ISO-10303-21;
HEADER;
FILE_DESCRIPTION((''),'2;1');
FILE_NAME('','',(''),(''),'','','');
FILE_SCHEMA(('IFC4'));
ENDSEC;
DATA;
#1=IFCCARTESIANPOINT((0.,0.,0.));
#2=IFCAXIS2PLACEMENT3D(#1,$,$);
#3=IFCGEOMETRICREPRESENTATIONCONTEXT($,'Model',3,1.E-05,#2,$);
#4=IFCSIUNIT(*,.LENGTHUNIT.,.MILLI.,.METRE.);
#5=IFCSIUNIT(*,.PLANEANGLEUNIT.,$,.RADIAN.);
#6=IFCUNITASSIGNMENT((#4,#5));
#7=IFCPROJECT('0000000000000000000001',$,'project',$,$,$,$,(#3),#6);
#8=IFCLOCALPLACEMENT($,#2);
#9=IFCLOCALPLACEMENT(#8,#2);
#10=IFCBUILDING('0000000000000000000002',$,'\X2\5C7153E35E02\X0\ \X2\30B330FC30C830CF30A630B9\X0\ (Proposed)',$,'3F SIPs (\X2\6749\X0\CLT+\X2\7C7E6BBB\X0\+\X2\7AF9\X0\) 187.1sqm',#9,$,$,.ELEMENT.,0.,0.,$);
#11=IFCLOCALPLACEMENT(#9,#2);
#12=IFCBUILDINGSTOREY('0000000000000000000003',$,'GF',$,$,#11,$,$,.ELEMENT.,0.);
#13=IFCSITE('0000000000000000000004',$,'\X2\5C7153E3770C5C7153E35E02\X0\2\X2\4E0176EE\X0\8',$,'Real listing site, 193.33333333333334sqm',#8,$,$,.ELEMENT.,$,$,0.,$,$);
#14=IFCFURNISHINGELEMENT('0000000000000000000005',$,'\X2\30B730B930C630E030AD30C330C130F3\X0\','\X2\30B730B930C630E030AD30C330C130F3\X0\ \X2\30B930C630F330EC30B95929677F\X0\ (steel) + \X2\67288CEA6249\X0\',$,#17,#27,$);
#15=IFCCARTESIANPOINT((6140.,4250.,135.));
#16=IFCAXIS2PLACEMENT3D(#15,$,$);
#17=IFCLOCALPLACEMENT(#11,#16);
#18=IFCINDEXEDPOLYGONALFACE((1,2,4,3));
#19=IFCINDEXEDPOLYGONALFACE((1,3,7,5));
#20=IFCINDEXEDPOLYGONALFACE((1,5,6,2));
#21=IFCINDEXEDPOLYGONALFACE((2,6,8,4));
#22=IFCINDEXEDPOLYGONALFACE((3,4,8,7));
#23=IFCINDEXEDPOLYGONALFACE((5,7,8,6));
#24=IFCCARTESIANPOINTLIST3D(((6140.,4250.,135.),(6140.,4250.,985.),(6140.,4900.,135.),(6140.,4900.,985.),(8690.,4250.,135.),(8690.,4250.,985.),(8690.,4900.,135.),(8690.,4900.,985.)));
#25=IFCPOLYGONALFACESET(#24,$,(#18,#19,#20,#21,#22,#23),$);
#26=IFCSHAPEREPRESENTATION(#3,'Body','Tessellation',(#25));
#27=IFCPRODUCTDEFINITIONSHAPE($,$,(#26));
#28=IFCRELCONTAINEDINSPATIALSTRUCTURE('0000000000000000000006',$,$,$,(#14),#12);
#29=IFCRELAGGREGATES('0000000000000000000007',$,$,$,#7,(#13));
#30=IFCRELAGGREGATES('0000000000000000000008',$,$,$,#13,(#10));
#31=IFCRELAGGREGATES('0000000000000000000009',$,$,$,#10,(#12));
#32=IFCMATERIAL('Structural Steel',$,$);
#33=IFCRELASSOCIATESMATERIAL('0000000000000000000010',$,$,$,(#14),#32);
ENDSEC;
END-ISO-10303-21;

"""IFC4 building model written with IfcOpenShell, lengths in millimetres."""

from ifc_helpers import new_model, si_unit, frame, frame_2d, origin, place, context, project, spatial, rectangle, extrude, material, element, save


model = new_model("IFC4")

# Units and contexts
model_context = context("Model", 3, precision=1e-05, world=origin())
ifc_project = project(units=[si_unit("LENGTHUNIT", "METRE", prefix="MILLI"), si_unit("PLANEANGLEUNIT", "RADIAN")], contexts=[model_context])

# Site, building, storey
site_placement = place(None, origin())
site = spatial("IfcSite", under=ifc_project, at=site_placement, Name="山口県山口市2丁目8", ObjectType="Real listing site, 193.33333333333334sqm", CompositionType="ELEMENT", RefElevation=0.0)
building_placement = place(site_placement, origin())
building = spatial("IfcBuilding", under=site, at=building_placement, Name="山口市 コートハウス (Proposed)", ObjectType="3F SIPs (杉CLT+籾殻+竹) 187.1sqm", CompositionType="ELEMENT", ElevationOfRefHeight=0.0, ElevationOfTerrain=0.0)
storey_placement = place(building_placement, origin())
storey = spatial("IfcBuildingStorey", under=building, at=storey_placement, Name="GF", CompositionType="ELEMENT", Elevation=0.0)

# Furnishing element
ifc_material_1 = material(Name="Structural Steel")
furnishing_1_placement = place(storey_placement, frame((6140.0, 4250.0, 135.0)))
element("IfcFurnishingElement", 1, at=furnishing_1_placement, inside=storey, material=ifc_material_1, Name="システムキッチン", Description="システムキッチン ステンレス天板 (steel) + 木質扉", context=model_context, shape_type="SweptSolid", body=[
    extrude(rectangle(XDim=2550.0, YDim=650.0, at=frame_2d((1275.0, 325.0))), frame((6140.0, 4250.0, 135.0)), (0.0, 0.0, 1.0), 850.0),
])

save(model, "model.ifc")
